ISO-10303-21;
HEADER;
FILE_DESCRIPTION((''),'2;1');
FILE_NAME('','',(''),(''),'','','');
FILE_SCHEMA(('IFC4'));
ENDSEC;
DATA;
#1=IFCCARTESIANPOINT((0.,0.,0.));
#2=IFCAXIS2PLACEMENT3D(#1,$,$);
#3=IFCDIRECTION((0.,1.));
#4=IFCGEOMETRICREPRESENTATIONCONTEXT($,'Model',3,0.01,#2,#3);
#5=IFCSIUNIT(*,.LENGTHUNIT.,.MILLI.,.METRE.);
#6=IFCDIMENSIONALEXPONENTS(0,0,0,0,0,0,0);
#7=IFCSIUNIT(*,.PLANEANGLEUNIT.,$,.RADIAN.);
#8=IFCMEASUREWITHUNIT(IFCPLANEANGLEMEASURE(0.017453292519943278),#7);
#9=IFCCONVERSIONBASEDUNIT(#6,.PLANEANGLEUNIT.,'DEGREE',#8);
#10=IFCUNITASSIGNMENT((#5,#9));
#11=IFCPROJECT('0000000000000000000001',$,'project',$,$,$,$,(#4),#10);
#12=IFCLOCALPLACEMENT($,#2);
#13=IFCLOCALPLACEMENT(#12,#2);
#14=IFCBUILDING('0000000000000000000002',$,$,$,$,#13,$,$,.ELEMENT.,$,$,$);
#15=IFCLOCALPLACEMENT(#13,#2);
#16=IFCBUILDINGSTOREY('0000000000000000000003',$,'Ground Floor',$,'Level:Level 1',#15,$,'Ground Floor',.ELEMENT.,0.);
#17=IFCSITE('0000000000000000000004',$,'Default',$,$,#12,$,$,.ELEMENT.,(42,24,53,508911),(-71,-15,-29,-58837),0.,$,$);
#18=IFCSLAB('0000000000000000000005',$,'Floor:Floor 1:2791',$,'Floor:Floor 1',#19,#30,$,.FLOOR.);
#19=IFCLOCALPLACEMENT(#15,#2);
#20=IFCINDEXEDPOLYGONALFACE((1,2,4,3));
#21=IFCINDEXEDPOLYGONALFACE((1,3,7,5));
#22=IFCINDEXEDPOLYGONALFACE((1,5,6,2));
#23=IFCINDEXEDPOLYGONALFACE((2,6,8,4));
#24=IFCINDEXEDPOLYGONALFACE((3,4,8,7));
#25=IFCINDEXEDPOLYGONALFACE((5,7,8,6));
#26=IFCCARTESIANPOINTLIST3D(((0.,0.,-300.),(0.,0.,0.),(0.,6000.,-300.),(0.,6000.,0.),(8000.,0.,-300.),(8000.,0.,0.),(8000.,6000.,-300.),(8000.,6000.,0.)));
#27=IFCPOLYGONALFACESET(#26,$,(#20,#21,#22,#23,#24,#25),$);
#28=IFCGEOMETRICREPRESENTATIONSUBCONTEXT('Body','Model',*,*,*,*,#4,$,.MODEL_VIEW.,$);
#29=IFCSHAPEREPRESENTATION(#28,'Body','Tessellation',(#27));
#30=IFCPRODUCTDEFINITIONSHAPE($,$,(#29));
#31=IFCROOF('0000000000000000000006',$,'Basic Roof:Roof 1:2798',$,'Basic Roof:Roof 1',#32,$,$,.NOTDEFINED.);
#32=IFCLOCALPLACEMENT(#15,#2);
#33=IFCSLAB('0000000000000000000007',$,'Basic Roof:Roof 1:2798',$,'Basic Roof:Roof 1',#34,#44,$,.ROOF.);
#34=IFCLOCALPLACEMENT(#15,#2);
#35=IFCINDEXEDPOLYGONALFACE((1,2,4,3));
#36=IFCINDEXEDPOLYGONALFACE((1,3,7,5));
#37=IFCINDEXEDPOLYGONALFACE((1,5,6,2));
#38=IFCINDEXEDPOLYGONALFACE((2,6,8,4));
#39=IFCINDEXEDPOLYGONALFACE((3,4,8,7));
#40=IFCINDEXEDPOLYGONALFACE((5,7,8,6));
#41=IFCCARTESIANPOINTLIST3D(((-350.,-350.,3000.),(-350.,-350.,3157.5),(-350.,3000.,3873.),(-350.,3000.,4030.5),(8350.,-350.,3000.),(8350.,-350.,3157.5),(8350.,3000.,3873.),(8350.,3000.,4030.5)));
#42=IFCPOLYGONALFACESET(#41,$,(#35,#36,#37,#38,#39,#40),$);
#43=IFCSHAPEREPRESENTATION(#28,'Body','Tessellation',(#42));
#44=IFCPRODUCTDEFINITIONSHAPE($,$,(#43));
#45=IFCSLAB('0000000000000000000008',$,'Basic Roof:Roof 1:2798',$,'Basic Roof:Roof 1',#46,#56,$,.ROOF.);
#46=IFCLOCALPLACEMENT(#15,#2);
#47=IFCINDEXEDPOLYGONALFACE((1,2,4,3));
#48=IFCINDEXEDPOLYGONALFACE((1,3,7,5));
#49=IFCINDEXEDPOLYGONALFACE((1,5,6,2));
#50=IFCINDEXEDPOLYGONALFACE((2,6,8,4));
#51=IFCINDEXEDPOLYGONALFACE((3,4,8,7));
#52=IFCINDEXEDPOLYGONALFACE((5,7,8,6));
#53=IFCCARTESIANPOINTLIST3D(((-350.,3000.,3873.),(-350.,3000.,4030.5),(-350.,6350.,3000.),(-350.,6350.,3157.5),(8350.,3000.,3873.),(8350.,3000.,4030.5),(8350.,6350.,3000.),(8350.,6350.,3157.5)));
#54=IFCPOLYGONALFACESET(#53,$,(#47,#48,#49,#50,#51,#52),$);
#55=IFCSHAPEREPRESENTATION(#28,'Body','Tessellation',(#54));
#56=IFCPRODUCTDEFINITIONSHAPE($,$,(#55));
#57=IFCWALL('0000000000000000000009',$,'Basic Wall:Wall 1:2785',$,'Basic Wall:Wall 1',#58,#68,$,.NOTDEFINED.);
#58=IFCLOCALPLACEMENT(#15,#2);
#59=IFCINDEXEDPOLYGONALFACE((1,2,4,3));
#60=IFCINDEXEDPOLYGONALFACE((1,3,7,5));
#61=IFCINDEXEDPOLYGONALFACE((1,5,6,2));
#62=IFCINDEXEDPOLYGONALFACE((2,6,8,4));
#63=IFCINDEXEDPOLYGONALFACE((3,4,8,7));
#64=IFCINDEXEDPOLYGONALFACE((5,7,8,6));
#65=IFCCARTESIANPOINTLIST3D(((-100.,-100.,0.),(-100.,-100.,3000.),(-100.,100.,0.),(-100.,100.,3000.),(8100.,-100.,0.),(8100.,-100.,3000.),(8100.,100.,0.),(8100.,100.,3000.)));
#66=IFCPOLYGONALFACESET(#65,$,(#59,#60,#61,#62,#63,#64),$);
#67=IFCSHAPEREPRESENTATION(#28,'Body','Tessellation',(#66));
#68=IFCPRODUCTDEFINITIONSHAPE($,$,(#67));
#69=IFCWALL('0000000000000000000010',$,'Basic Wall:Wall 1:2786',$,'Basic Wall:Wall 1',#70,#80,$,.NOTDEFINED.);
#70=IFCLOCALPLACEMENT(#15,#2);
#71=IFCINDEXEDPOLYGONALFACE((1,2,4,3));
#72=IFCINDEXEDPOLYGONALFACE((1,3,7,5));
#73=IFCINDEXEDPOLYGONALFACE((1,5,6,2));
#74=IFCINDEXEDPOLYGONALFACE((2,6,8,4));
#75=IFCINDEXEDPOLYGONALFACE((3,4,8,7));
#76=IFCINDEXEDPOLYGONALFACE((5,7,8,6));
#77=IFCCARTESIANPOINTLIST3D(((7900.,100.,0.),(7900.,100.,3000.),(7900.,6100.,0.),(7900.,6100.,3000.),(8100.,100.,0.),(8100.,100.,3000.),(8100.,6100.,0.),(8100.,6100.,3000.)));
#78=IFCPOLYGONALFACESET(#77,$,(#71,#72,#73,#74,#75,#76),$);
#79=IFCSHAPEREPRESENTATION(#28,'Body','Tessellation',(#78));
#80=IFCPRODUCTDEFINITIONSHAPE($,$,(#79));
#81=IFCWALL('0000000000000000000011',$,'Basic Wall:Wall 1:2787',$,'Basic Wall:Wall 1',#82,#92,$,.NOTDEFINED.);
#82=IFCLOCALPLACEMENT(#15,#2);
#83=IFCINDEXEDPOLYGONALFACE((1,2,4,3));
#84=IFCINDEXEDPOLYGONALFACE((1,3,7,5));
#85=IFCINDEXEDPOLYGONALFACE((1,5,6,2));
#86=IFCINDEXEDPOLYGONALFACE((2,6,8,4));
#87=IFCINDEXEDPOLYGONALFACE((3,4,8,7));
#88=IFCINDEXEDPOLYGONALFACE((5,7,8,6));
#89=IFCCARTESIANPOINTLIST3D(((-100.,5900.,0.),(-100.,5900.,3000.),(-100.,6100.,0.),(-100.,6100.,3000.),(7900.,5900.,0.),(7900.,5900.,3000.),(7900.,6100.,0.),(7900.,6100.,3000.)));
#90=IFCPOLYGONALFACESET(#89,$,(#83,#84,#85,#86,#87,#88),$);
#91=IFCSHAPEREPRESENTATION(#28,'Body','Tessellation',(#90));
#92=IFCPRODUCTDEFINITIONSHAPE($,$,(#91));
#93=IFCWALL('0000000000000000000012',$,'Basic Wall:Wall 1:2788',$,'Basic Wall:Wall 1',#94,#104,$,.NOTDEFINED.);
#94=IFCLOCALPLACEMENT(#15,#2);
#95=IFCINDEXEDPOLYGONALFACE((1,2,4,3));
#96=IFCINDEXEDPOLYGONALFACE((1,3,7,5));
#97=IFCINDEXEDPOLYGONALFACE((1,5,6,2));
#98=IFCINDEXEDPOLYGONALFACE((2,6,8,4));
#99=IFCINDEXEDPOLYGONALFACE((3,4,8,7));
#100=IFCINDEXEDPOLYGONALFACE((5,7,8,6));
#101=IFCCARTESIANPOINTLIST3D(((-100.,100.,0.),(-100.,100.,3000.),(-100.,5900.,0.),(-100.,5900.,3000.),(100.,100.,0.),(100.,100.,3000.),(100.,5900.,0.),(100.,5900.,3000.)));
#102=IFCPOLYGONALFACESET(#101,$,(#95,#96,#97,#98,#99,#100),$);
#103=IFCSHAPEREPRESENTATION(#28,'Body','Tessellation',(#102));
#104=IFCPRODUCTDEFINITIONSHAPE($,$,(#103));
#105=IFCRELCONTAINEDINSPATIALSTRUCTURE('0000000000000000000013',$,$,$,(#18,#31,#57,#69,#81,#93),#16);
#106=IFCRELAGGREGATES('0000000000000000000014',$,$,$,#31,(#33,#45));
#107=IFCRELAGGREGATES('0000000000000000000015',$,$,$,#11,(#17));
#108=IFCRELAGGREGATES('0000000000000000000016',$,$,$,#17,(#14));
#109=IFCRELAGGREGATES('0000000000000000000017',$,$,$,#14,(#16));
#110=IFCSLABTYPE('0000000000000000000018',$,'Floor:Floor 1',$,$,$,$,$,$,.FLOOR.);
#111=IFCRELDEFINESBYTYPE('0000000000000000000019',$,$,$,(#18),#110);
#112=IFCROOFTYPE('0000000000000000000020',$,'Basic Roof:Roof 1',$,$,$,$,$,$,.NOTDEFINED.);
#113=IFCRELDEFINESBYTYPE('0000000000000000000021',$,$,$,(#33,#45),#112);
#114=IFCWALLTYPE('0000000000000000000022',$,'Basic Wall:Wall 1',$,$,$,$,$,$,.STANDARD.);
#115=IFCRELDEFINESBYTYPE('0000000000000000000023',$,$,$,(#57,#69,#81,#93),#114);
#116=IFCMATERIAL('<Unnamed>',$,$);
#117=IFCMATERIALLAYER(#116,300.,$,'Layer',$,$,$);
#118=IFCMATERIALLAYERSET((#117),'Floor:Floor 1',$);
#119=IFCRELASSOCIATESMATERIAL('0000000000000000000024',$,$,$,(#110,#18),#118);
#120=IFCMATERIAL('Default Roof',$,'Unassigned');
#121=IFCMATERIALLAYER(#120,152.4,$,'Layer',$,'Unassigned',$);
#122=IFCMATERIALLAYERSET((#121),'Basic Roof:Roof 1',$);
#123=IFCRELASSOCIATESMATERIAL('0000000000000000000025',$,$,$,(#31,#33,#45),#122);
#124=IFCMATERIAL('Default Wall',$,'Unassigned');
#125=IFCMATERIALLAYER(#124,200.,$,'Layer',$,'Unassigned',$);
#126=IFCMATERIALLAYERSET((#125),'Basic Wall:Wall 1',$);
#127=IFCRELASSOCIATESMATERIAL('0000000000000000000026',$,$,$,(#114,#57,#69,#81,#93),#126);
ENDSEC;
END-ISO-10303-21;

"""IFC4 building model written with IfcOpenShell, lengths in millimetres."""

from ifc_helpers import new_model, entity, si_unit, converted_unit, direction, frame, frame_2d, origin, origin_2d_with_axis, place, context, subcontext, project, spatial, rectangle, extrude, material, layer, layer_set, layer_usage, type_object, element, aggregate, save


model = new_model("IFC4")

# Units and contexts
model_context = context("Model", 3, precision=0.01, world=origin(), true_north=direction((0.0, 1.0)))
body_context = subcontext(model_context, "Body", "Model", "MODEL_VIEW")
ifc_project = project(units=[si_unit("LENGTHUNIT", "METRE", prefix="MILLI"), converted_unit("PLANEANGLEUNIT", "DEGREE", entity("IfcPlaneAngleMeasure", 0.017453292519943278), si_unit("PLANEANGLEUNIT", "RADIAN"), dimensions=[0, 0, 0, 0, 0, 0, 0])], contexts=[model_context])

# Site, building, storey
site_placement = place(None, origin())
site = spatial("IfcSite", under=ifc_project, at=site_placement, Name="Default", CompositionType="ELEMENT", RefLatitude=(42, 24, 53, 508911), RefLongitude=(-71, -15, -29, -58837), RefElevation=0.0)
building_placement = place(site_placement, origin())
building = spatial("IfcBuilding", under=site, at=building_placement, CompositionType="ELEMENT")
storey_placement = place(building_placement, origin())
storey = spatial("IfcBuildingStorey", under=building, at=storey_placement, Name="Ground Floor", ObjectType="Level:Level 1", LongName="Ground Floor", CompositionType="ELEMENT", Elevation=0.0)

# Slab
ifc_material_1 = material(Name="<Unnamed>")
ifc_layer_1 = layer(ifc_material_1, 300.0, Name="Layer")
ifc_layer_set_1 = layer_set([ifc_layer_1], Name="Floor:Floor 1")
ifc_layer_usage_1 = layer_usage(ifc_layer_set_1, "AXIS3", "POSITIVE", 0.0)
slab_type = type_object("IfcSlabType", Name="Floor:Floor 1", PredefinedType="FLOOR", material=ifc_layer_set_1)
slab_1_placement = place(storey_placement, origin())
element("IfcSlab", 1, at=slab_1_placement, inside=storey, type_object=slab_type, material=ifc_layer_usage_1, Name="Floor:Floor 1:2791", ObjectType="Floor:Floor 1", PredefinedType="FLOOR", context=body_context, shape_type="SweptSolid", body=[
    extrude(rectangle(XDim=6000.0, YDim=8000.0, at=origin_2d_with_axis()), frame((4000.0, 3000.0, 0.0), z_axis=(0.0, 0.0, -1.0), x_axis=(0.0, 1.0, 0.0)), (0.0, 0.0, 1.0), 300.0),
])

# Roof, slabs
ifc_material_2 = material(Name="Default Roof", Category="Unassigned")
ifc_layer_2 = layer(ifc_material_2, 152.4, Name="Layer", Category="Unassigned")
ifc_layer_set_2 = layer_set([ifc_layer_2], Name="Basic Roof:Roof 1")
roof_placement = place(storey_placement, frame((-350.0, -350.0, 3000.0)))
roof = element("IfcRoof", 2, at=roof_placement, inside=storey, material=ifc_layer_set_2, Name="Basic Roof:Roof 1:2798", ObjectType="Basic Roof:Roof 1", PredefinedType="NOTDEFINED")
roof_type = type_object("IfcRoofType", Name="Basic Roof:Roof 1", PredefinedType="NOTDEFINED")
slab_2_placement = place(roof_placement, origin())
slab_2 = element("IfcSlab", 3, at=slab_2_placement, type_object=roof_type, material=ifc_layer_set_2, Name="Basic Roof:Roof 1:2798", ObjectType="Basic Roof:Roof 1", PredefinedType="ROOF", context=body_context, shape_type="SweptSolid", body=[
    extrude(rectangle(XDim=8700.0, YDim=3461.9, at=frame_2d((0.0, 0.0), x_axis=(-1.0, 0.0))), frame((4350.0, 1675.0, 436.5), z_axis=(0.0, -0.25218, 0.96768), x_axis=(1.0, 0.0, 0.0)), (0.0, 0.25218, 0.96768), 157.5),
])
slab_3_placement = place(roof_placement, origin())
slab_3 = element("IfcSlab", 4, at=slab_3_placement, type_object=roof_type, material=ifc_layer_set_2, Name="Basic Roof:Roof 1:2798", ObjectType="Basic Roof:Roof 1", PredefinedType="ROOF", context=body_context, shape_type="SweptSolid", body=[
    extrude(rectangle(XDim=3461.9, YDim=8700.0, at=frame_2d((0.0, 0.0), x_axis=(0.0, -1.0))), frame((4350.0, 5025.0, 436.5), z_axis=(0.0, 0.25218, 0.96768), x_axis=(1.0, 0.0, 0.0)), (0.0, -0.25218, 0.96768), 157.5),
])
aggregate(roof, [slab_2, slab_3])

# Walls
ifc_material_3 = material(Name="Default Wall", Category="Unassigned")
ifc_layer_3 = layer(ifc_material_3, 200.0, Name="Layer", Category="Unassigned")
ifc_layer_set_3 = layer_set([ifc_layer_3], Name="Basic Wall:Wall 1")
ifc_layer_usage_2 = layer_usage(ifc_layer_set_3, "AXIS2", "NEGATIVE", 100.0)
wall_type = type_object("IfcWallType", Name="Basic Wall:Wall 1", PredefinedType="STANDARD", material=ifc_layer_set_3)
wall_1_placement = place(storey_placement, frame((-100.0, 0.0, 0.0)))
element("IfcWall", 5, at=wall_1_placement, inside=storey, type_object=wall_type, material=ifc_layer_usage_2, Name="Basic Wall:Wall 1:2785", ObjectType="Basic Wall:Wall 1", PredefinedType="NOTDEFINED", context=body_context, shape_type="SweptSolid", body=[
    extrude(rectangle(XDim=8200.0, YDim=200.0, at=frame_2d((4100.0, 0.0), x_axis=(-1.0, 0.0))), origin(), (0.0, 0.0, 1.0), 3000.0),
])
ifc_layer_usage_3 = layer_usage(ifc_layer_set_3, "AXIS2", "NEGATIVE", 100.0)
wall_2_placement = place(storey_placement, frame((8000.0, 100.0, 0.0), z_axis=(0.0, 0.0, 1.0), x_axis=(0.0, 1.0, 0.0)))
element("IfcWall", 6, at=wall_2_placement, inside=storey, type_object=wall_type, material=ifc_layer_usage_3, Name="Basic Wall:Wall 1:2786", ObjectType="Basic Wall:Wall 1", PredefinedType="NOTDEFINED", context=body_context, shape_type="SweptSolid", body=[
    extrude(rectangle(XDim=6000.0, YDim=200.0, at=frame_2d((3000.0, 0.0), x_axis=(-1.0, 0.0))), origin(), (0.0, 0.0, 1.0), 3000.0),
])
ifc_layer_usage_4 = layer_usage(ifc_layer_set_3, "AXIS2", "NEGATIVE", 100.0)
wall_3_placement = place(storey_placement, frame((7900.0, 6000.0, 0.0), z_axis=(0.0, 0.0, 1.0), x_axis=(-1.0, 0.0, 0.0)))
element("IfcWall", 7, at=wall_3_placement, inside=storey, type_object=wall_type, material=ifc_layer_usage_4, Name="Basic Wall:Wall 1:2787", ObjectType="Basic Wall:Wall 1", PredefinedType="NOTDEFINED", context=body_context, shape_type="SweptSolid", body=[
    extrude(rectangle(XDim=8000.0, YDim=200.0, at=frame_2d((4000.0, 0.0), x_axis=(-1.0, 0.0))), origin(), (0.0, 0.0, 1.0), 3000.0),
])
ifc_layer_usage_5 = layer_usage(ifc_layer_set_3, "AXIS2", "NEGATIVE", 100.0)
wall_4_placement = place(storey_placement, frame((0.0, 5900.0, 0.0), z_axis=(0.0, 0.0, 1.0), x_axis=(0.0, -1.0, 0.0)))
element("IfcWall", 8, at=wall_4_placement, inside=storey, type_object=wall_type, material=ifc_layer_usage_5, Name="Basic Wall:Wall 1:2788", ObjectType="Basic Wall:Wall 1", PredefinedType="NOTDEFINED", context=body_context, shape_type="SweptSolid", body=[
    extrude(rectangle(XDim=5800.0, YDim=200.0, at=frame_2d((2900.0, 0.0), x_axis=(-1.0, 0.0))), origin(), (0.0, 0.0, 1.0), 3000.0),
])

save(model, "model.ifc")
